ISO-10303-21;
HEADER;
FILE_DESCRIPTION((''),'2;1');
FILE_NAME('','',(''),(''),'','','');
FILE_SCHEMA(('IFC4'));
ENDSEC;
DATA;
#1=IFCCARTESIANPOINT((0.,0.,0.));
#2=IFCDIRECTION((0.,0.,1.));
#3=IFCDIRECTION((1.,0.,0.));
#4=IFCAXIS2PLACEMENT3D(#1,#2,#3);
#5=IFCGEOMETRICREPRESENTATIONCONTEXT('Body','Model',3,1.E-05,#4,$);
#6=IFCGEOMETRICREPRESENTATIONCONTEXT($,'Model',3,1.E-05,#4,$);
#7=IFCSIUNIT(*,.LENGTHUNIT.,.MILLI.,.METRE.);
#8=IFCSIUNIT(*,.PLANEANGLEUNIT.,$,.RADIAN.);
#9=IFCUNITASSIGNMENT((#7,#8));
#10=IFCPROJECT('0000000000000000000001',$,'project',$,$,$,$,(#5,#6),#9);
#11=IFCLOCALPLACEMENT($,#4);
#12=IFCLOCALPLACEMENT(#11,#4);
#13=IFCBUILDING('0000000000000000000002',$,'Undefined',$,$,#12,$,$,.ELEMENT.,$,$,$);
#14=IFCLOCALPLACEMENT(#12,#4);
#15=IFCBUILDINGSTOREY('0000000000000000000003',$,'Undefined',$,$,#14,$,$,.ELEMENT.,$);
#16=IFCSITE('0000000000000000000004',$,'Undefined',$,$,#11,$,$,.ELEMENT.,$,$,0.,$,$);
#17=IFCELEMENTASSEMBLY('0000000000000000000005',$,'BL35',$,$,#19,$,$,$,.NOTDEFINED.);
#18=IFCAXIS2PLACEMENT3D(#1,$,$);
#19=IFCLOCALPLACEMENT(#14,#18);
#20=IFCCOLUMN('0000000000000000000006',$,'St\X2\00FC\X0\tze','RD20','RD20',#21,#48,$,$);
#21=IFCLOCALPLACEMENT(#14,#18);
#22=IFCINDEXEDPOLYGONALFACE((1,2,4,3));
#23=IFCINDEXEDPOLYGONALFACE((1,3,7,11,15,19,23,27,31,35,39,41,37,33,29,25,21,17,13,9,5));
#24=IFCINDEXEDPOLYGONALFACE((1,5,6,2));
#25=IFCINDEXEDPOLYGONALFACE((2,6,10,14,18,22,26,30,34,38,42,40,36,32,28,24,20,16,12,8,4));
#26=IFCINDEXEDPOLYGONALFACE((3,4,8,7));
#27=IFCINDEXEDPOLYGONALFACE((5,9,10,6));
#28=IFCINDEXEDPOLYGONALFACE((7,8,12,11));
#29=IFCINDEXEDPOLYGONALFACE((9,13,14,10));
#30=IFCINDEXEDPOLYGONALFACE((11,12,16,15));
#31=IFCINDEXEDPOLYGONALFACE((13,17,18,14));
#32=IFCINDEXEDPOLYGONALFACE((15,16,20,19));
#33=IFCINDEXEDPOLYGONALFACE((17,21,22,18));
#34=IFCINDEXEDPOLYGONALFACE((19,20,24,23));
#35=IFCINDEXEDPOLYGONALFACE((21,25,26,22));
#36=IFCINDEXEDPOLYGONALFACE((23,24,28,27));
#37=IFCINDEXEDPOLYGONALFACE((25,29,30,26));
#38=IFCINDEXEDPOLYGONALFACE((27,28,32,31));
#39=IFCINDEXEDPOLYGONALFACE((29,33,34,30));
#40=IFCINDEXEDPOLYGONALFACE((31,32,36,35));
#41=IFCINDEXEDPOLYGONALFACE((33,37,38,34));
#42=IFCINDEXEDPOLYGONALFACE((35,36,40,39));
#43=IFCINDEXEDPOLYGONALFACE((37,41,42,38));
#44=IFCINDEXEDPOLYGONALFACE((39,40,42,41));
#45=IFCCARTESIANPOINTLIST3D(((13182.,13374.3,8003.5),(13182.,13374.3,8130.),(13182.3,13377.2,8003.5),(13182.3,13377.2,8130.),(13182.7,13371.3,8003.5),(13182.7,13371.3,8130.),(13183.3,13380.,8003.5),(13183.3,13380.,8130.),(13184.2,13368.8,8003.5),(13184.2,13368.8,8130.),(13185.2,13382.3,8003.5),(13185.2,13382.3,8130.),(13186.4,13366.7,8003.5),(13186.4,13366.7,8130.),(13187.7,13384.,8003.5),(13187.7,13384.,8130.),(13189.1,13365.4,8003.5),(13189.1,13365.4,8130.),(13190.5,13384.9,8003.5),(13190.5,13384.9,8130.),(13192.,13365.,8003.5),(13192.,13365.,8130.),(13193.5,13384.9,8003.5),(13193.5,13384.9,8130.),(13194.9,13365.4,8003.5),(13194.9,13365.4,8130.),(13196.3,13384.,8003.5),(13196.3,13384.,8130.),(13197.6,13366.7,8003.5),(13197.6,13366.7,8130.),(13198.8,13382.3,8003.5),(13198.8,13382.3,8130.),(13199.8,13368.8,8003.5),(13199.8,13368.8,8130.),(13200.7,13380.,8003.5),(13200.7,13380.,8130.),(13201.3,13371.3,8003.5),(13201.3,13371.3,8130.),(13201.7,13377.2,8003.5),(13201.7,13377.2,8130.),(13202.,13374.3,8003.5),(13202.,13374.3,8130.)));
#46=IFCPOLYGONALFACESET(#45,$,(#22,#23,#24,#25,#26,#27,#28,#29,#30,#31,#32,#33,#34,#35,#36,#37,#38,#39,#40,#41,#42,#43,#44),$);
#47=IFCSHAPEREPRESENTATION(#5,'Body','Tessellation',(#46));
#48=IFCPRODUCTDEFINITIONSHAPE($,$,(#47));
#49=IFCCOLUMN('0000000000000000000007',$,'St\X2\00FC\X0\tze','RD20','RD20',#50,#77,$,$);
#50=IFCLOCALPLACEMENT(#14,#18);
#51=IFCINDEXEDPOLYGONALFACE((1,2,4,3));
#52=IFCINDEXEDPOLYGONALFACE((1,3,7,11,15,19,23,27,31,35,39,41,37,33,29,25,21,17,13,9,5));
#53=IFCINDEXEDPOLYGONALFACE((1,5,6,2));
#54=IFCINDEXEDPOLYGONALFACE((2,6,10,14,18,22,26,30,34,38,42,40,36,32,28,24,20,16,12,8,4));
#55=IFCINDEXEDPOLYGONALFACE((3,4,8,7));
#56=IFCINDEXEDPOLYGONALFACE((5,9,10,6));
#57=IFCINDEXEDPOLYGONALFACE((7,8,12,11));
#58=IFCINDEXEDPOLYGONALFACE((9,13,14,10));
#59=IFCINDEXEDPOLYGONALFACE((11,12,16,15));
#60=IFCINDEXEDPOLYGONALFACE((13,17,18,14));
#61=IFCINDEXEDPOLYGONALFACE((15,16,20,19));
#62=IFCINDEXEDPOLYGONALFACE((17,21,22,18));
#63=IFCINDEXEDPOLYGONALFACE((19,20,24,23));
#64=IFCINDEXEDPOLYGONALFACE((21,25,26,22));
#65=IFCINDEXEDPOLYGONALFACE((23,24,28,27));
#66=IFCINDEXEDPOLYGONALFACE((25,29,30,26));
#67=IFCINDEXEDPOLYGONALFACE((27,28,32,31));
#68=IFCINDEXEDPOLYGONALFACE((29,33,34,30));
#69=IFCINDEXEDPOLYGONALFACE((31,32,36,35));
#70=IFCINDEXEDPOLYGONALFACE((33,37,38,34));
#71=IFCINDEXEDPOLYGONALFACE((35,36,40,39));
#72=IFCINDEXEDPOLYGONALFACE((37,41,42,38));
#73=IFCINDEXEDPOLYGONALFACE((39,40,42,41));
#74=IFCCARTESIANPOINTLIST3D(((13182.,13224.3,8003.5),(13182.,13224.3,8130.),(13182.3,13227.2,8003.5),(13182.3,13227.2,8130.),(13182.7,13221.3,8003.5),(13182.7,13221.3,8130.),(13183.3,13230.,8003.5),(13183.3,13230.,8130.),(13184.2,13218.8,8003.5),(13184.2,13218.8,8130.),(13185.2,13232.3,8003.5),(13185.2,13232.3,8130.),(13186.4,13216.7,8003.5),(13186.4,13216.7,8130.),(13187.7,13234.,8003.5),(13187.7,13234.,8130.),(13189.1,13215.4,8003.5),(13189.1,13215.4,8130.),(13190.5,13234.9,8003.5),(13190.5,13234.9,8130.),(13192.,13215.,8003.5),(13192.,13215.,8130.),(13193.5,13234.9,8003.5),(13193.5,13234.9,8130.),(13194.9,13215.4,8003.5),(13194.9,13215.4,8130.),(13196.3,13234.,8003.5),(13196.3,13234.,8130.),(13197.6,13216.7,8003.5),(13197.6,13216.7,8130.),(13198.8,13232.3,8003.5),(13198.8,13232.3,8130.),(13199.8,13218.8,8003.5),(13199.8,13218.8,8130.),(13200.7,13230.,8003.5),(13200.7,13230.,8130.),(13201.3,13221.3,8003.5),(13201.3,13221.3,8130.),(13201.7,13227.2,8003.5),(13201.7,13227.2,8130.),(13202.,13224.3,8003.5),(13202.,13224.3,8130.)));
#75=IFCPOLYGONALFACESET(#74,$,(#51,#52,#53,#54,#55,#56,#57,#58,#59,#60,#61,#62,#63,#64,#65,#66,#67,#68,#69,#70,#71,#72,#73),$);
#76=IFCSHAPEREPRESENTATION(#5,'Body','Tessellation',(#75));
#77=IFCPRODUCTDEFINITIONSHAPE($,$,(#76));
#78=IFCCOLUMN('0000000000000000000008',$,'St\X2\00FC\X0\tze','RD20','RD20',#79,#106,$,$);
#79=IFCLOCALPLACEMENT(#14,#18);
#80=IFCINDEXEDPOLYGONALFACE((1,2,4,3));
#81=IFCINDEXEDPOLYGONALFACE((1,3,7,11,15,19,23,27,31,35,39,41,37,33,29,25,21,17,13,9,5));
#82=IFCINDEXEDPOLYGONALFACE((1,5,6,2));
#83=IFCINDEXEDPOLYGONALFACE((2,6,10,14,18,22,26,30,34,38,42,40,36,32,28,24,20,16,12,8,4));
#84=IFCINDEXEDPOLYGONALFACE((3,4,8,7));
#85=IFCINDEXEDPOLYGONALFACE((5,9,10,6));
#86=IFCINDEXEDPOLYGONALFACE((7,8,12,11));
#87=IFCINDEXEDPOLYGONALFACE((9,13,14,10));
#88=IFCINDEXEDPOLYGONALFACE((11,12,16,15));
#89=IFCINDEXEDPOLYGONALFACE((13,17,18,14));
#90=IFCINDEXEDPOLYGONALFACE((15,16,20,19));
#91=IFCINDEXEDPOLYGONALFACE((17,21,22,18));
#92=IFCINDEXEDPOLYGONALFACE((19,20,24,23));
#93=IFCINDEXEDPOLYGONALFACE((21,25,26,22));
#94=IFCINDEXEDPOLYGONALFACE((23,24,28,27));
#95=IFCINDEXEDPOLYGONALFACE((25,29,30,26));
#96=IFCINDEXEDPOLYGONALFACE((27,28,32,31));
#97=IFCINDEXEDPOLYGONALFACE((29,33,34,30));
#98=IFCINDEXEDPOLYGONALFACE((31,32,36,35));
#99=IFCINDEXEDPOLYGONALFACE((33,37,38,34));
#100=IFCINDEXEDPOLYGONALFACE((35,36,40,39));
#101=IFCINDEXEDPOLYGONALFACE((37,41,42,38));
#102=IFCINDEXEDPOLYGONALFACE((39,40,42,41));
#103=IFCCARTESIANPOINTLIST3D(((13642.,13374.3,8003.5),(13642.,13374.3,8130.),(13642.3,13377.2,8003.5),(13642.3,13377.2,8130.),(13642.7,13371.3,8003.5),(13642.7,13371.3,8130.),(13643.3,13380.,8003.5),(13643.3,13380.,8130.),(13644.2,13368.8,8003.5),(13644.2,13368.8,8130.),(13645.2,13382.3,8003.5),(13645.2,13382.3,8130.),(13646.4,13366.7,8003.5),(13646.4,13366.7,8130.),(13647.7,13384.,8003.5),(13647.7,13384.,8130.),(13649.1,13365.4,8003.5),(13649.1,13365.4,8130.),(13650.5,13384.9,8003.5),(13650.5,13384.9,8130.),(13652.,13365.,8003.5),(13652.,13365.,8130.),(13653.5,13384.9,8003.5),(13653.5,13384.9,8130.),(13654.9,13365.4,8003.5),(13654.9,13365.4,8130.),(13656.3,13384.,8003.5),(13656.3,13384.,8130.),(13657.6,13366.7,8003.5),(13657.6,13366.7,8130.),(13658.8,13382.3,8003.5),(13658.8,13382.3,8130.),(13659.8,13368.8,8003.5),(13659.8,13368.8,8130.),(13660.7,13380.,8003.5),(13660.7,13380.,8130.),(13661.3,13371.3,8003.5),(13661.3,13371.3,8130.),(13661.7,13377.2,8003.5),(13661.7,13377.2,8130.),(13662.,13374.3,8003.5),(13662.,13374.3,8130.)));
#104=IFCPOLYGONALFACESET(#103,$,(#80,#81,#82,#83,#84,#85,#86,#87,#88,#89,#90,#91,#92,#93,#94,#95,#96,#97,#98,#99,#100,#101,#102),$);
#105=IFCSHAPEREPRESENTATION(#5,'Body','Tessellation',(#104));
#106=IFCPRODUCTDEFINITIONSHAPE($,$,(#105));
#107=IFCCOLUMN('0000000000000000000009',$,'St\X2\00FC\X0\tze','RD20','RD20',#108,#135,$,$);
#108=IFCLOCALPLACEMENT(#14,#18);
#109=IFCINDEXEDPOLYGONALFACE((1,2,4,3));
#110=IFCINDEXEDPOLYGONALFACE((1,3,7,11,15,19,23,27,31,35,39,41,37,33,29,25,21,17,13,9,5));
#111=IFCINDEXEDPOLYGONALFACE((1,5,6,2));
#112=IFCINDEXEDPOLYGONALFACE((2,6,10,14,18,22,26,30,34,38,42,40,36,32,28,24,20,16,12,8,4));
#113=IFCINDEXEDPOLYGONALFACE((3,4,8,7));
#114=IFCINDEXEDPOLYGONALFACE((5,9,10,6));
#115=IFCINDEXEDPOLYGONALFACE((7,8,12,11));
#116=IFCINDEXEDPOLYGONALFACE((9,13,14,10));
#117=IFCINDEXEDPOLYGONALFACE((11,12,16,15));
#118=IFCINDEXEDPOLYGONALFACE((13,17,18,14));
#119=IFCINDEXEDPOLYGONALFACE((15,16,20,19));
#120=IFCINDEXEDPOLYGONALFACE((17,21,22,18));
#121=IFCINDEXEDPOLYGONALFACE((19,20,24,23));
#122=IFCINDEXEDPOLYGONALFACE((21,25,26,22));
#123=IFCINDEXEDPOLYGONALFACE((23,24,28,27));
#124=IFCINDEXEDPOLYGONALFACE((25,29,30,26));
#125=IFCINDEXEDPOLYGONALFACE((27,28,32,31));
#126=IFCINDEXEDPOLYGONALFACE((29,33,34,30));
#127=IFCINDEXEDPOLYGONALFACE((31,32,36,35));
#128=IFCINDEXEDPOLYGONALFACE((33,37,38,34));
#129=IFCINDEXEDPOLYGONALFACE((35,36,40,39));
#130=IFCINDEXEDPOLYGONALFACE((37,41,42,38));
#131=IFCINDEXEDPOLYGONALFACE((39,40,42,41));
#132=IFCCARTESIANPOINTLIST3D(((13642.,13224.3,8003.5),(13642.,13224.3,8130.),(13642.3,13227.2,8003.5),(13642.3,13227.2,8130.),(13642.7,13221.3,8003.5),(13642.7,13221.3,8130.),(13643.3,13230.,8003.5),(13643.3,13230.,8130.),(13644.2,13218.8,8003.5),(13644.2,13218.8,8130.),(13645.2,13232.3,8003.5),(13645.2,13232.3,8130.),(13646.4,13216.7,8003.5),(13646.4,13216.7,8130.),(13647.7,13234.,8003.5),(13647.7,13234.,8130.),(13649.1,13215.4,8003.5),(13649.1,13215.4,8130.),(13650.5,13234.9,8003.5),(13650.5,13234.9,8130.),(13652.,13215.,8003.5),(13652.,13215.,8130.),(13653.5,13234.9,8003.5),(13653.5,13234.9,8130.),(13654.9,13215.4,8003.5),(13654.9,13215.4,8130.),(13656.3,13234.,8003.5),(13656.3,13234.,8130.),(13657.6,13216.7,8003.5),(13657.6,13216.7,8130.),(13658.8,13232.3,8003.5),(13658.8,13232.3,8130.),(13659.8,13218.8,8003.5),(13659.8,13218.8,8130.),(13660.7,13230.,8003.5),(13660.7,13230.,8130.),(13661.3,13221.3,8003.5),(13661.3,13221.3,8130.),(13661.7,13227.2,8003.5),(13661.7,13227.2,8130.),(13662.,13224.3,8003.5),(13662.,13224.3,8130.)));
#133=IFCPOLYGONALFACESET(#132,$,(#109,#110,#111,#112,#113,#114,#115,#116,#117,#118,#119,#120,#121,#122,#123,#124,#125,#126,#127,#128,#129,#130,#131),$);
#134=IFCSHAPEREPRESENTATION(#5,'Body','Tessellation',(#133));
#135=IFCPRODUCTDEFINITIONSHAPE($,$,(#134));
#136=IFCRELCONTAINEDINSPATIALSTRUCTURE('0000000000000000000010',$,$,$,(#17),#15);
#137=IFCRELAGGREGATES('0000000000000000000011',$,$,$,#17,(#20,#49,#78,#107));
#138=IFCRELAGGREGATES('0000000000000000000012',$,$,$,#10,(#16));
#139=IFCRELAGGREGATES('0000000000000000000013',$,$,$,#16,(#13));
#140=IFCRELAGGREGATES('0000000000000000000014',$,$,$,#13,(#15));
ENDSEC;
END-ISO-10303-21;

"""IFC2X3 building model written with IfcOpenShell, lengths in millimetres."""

from ifc_helpers import new_model, si_unit, frame, origin_with_axes, origin_2d_with_axis, place, context, project, spatial, circle, extrude, element, aggregate, save


model = new_model("IFC2X3")

# Units and contexts
model_context_1 = context("Model", 3, precision=1e-05, world=origin_with_axes(), identifier="Body")
model_context_2 = context("Model", 3, precision=1e-05, world=origin_with_axes())
ifc_project = project(units=[si_unit("LENGTHUNIT", "METRE", prefix="MILLI"), si_unit("PLANEANGLEUNIT", "RADIAN")], contexts=[model_context_1, model_context_2])

# Site, building, storey
site_placement = place(None, origin_with_axes())
site = spatial("IfcSite", under=ifc_project, at=site_placement, Name="Undefined", CompositionType="ELEMENT", RefElevation=0.0)
building_placement = place(site_placement, origin_with_axes())
building = spatial("IfcBuilding", under=site, at=building_placement, Name="Undefined", CompositionType="ELEMENT")
storey_placement = place(building_placement, origin_with_axes())
storey = spatial("IfcBuildingStorey", under=building, at=storey_placement, Name="Undefined", CompositionType="ELEMENT")

# Element assembly, columns
assembly_1 = element("IfcElementAssembly", 1, inside=storey, Name="BL35", PredefinedType="NOTDEFINED")
column_1_placement = place(storey_placement, frame((13192.0, 13375.0, 8003.5), z_axis=(0.0, 0.0, 1.0), x_axis=(1.0, 0.0, 0.0)))
column_1 = element("IfcColumn", 2, at=column_1_placement, Name="Stütze", Description="RD20", ObjectType="RD20", context=model_context_1, shape_type="SweptSolid", body=[
    extrude(circle(Radius=10.0, at=origin_2d_with_axis()), frame((0.0, 0.0, 126.5), z_axis=(0.0, 0.0, -1.0), x_axis=(0.0, -1.0, 0.0)), (0.0, 0.0, 1.0), 126.5),
])
column_2_placement = place(storey_placement, frame((13192.0, 13225.0, 8003.5), z_axis=(0.0, 0.0, 1.0), x_axis=(1.0, 0.0, 0.0)))
column_2 = element("IfcColumn", 3, at=column_2_placement, Name="Stütze", Description="RD20", ObjectType="RD20", context=model_context_1, shape_type="SweptSolid", body=[
    extrude(circle(Radius=10.0, at=origin_2d_with_axis()), frame((0.0, 0.0, 126.5), z_axis=(0.0, 0.0, -1.0), x_axis=(0.0, -1.0, 0.0)), (0.0, 0.0, 1.0), 126.5),
])
column_3_placement = place(storey_placement, frame((13652.0, 13375.0, 8003.5), z_axis=(0.0, 0.0, 1.0), x_axis=(1.0, 0.0, 0.0)))
column_3 = element("IfcColumn", 4, at=column_3_placement, Name="Stütze", Description="RD20", ObjectType="RD20", context=model_context_1, shape_type="SweptSolid", body=[
    extrude(circle(Radius=10.0, at=origin_2d_with_axis()), frame((0.0, 0.0, 126.5), z_axis=(0.0, 0.0, -1.0), x_axis=(0.0, -1.0, 0.0)), (0.0, 0.0, 1.0), 126.5),
])
column_4_placement = place(storey_placement, frame((13652.0, 13225.0, 8003.5), z_axis=(0.0, 0.0, 1.0), x_axis=(1.0, 0.0, 0.0)))
column_4 = element("IfcColumn", 5, at=column_4_placement, Name="Stütze", Description="RD20", ObjectType="RD20", context=model_context_1, shape_type="SweptSolid", body=[
    extrude(circle(Radius=10.0, at=origin_2d_with_axis()), frame((0.0, 0.0, 126.5), z_axis=(0.0, 0.0, -1.0), x_axis=(0.0, -1.0, 0.0)), (0.0, 0.0, 1.0), 126.5),
])
aggregate(assembly_1, [column_1, column_2, column_3, column_4])

save(model, "model.ifc")
